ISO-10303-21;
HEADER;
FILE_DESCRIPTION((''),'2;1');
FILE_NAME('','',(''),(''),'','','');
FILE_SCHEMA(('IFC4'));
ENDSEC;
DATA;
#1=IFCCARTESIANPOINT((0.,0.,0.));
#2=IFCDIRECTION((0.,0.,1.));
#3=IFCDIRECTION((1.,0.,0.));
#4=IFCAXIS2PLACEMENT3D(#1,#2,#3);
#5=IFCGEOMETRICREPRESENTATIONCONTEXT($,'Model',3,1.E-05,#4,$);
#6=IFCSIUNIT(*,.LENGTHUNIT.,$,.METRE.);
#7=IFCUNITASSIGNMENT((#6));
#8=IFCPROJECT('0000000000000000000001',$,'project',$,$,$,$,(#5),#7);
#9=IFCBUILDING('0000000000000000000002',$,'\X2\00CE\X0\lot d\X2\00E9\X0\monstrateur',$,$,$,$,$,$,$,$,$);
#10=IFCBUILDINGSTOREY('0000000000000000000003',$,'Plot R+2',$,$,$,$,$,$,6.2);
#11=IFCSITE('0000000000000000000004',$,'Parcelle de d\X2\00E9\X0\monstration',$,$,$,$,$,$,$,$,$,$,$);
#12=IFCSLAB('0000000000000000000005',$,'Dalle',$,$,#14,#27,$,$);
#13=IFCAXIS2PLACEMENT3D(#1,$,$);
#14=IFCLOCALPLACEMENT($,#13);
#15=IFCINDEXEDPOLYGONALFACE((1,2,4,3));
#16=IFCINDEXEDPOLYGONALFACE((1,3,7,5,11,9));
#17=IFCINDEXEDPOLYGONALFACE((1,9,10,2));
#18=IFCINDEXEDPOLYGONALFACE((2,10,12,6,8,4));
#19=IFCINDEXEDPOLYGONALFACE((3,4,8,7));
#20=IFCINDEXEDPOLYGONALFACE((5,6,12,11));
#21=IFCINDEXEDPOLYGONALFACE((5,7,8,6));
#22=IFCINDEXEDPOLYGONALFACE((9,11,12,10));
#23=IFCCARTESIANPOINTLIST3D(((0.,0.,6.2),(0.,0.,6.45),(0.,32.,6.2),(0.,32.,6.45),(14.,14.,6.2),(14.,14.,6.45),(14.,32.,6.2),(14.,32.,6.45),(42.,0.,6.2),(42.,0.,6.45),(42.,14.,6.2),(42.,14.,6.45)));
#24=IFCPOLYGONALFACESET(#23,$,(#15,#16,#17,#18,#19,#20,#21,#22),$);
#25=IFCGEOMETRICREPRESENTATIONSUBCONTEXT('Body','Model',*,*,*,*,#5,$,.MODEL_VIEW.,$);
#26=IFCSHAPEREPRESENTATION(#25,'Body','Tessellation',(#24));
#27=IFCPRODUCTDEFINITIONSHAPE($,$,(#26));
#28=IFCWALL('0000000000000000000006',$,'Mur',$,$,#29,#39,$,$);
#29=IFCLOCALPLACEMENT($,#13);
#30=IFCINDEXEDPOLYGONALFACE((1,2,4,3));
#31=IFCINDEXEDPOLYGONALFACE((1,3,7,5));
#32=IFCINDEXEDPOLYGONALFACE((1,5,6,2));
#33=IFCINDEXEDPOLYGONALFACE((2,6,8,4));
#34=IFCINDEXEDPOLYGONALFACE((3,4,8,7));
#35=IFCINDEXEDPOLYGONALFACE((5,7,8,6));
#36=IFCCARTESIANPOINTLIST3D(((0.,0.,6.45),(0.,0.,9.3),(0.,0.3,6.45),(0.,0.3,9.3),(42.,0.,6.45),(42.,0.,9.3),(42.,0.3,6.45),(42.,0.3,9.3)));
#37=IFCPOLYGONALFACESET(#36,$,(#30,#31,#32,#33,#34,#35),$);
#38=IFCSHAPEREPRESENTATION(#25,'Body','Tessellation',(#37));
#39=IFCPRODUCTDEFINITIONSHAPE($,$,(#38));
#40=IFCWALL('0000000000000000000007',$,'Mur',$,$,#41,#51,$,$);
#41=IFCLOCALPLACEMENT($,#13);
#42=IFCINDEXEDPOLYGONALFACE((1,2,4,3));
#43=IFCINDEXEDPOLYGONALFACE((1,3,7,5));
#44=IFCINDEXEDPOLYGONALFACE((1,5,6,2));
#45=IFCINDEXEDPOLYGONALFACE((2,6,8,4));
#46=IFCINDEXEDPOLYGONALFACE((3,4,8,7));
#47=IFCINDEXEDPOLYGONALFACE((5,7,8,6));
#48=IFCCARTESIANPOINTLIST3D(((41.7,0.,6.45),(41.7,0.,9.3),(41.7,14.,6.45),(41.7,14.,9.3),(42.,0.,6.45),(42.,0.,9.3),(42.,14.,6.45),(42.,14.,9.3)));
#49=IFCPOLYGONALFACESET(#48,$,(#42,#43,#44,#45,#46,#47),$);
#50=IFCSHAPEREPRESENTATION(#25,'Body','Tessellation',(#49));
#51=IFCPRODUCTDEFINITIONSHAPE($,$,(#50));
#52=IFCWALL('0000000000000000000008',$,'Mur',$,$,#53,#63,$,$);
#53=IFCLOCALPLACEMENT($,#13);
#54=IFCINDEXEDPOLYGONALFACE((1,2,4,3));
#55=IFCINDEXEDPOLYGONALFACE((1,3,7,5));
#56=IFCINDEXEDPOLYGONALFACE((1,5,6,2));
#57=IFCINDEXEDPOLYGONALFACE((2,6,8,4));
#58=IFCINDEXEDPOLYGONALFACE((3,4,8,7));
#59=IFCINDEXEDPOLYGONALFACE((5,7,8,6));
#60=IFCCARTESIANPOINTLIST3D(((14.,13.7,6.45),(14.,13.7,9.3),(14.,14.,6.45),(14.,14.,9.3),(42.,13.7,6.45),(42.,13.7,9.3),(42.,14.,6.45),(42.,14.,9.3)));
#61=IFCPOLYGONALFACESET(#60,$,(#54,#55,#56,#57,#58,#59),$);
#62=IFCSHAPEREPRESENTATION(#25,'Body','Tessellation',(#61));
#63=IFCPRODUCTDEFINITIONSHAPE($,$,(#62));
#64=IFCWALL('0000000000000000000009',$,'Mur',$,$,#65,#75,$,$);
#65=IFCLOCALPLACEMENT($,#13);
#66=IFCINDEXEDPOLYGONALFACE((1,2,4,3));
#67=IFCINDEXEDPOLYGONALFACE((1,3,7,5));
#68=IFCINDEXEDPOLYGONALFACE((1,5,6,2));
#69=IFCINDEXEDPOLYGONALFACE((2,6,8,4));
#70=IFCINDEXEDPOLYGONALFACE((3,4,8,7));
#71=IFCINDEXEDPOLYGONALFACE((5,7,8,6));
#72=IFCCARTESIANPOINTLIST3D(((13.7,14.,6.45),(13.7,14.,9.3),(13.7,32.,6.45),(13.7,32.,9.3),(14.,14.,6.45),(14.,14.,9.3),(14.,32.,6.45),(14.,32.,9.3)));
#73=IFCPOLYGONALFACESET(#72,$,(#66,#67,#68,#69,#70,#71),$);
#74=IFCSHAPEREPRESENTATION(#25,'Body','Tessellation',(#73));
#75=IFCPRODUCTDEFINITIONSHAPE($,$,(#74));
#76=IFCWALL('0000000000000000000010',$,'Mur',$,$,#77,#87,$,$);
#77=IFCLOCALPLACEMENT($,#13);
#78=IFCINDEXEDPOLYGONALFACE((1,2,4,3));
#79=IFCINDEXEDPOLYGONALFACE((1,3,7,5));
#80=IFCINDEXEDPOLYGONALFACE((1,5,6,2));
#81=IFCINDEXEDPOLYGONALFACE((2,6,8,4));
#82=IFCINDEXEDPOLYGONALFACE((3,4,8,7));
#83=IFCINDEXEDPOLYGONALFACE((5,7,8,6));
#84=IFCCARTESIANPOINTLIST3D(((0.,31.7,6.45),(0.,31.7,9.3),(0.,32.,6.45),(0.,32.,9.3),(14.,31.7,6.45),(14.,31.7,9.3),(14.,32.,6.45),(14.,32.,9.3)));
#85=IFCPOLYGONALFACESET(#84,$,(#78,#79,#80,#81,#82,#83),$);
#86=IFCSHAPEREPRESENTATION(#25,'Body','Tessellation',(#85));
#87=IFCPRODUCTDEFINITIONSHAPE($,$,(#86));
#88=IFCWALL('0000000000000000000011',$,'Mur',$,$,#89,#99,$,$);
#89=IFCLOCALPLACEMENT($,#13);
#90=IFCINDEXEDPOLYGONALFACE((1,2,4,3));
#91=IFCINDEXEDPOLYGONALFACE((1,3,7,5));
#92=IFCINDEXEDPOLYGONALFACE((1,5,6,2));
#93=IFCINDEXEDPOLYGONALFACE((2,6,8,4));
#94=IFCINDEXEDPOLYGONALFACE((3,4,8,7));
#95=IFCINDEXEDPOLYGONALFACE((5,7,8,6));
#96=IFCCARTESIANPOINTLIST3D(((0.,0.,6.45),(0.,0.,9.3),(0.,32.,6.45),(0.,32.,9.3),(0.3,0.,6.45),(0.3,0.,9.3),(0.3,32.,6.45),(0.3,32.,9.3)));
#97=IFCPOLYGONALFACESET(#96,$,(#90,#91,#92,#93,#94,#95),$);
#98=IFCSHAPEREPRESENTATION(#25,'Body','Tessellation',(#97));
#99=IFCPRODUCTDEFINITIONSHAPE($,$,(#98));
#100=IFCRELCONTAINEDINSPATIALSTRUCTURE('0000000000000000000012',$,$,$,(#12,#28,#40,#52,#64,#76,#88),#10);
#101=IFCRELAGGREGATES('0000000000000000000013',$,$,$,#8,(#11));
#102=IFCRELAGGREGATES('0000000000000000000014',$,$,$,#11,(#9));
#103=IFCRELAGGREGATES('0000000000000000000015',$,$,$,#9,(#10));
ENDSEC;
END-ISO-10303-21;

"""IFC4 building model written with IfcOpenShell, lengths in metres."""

from ifc_helpers import new_model, si_unit, frame, origin_with_axes, place, context, subcontext, project, spatial, indexed_curve, outline, extrude, element, save


model = new_model("IFC4")

# Units and contexts
model_context = context("Model", 3, precision=1e-05, world=origin_with_axes())
body_context = subcontext(model_context, "Body", "Model", "MODEL_VIEW")
ifc_project = project(units=[si_unit("LENGTHUNIT", "METRE")], contexts=[model_context])

# Site, building, storey
site = spatial("IfcSite", under=ifc_project, Name="Parcelle de démonstration")
building = spatial("IfcBuilding", under=site, Name="Îlot démonstrateur")
storey = spatial("IfcBuildingStorey", under=building, Name="Plot R+2", Elevation=6.2)

# Slab
slab_placement = place(None, frame((0.0, 0.0, 6.2), z_axis=(0.0, 0.0, 1.0), x_axis=(1.0, 0.0, 0.0)))
element("IfcSlab", 1, at=slab_placement, inside=storey, Name="Dalle", context=body_context, shape_type="SweptSolid", body=[
    extrude(outline(indexed_curve([(0.0, 0.0), (42.0, 0.0), (42.0, 14.0), (14.0, 14.0), (14.0, 32.0), (0.0, 32.0)])), None, (0.0, 0.0, 1.0), 0.25),
])

# Walls
wall_1_placement = place(None, frame((0.0, 0.0, 6.45), z_axis=(0.0, 0.0, 1.0), x_axis=(1.0, 0.0, 0.0)))
element("IfcWall", 2, at=wall_1_placement, inside=storey, Name="Mur", context=body_context, shape_type="SweptSolid", body=[
    extrude(outline(indexed_curve([(0.0, 0.0), (0.0, 0.3), (42.0, 0.3), (42.0, 0.0), (0.0, 0.0)], self_intersect=False)), origin_with_axes(), (0.0, 0.0, 1.0), 2.85),
])
wall_2_placement = place(None, frame((42.0, 0.0, 6.45), z_axis=(0.0, 0.0, 1.0), x_axis=(0.0, 1.0, 0.0)))
element("IfcWall", 3, at=wall_2_placement, inside=storey, Name="Mur", context=body_context, shape_type="SweptSolid", body=[
    extrude(outline(indexed_curve([(0.0, 0.0), (0.0, 0.3), (14.0, 0.3), (14.0, 0.0), (0.0, 0.0)], self_intersect=False)), origin_with_axes(), (0.0, 0.0, 1.0), 2.85),
])
wall_3_placement = place(None, frame((42.0, 14.0, 6.45), z_axis=(0.0, 0.0, 1.0), x_axis=(-1.0, 0.0, 0.0)))
element("IfcWall", 4, at=wall_3_placement, inside=storey, Name="Mur", context=body_context, shape_type="SweptSolid", body=[
    extrude(outline(indexed_curve([(0.0, 0.0), (0.0, 0.3), (28.0, 0.3), (28.0, 0.0), (0.0, 0.0)], self_intersect=False)), origin_with_axes(), (0.0, 0.0, 1.0), 2.85),
])
wall_4_placement = place(None, frame((14.0, 14.0, 6.45), z_axis=(0.0, 0.0, 1.0), x_axis=(0.0, 1.0, 0.0)))
element("IfcWall", 5, at=wall_4_placement, inside=storey, Name="Mur", context=body_context, shape_type="SweptSolid", body=[
    extrude(outline(indexed_curve([(0.0, 0.0), (0.0, 0.3), (18.0, 0.3), (18.0, 0.0), (0.0, 0.0)], self_intersect=False)), origin_with_axes(), (0.0, 0.0, 1.0), 2.85),
])
wall_5_placement = place(None, frame((14.0, 32.0, 6.45), z_axis=(0.0, 0.0, 1.0), x_axis=(-1.0, 0.0, 0.0)))
element("IfcWall", 6, at=wall_5_placement, inside=storey, Name="Mur", context=body_context, shape_type="SweptSolid", body=[
    extrude(outline(indexed_curve([(0.0, 0.0), (0.0, 0.3), (14.0, 0.3), (14.0, 0.0), (0.0, 0.0)], self_intersect=False)), origin_with_axes(), (0.0, 0.0, 1.0), 2.85),
])
wall_6_placement = place(None, frame((0.0, 32.0, 6.45), z_axis=(0.0, 0.0, 1.0), x_axis=(0.0, -1.0, 0.0)))
element("IfcWall", 7, at=wall_6_placement, inside=storey, Name="Mur", context=body_context, shape_type="SweptSolid", body=[
    extrude(outline(indexed_curve([(0.0, 0.0), (0.0, 0.3), (32.0, 0.3), (32.0, 0.0), (0.0, 0.0)], self_intersect=False)), origin_with_axes(), (0.0, 0.0, 1.0), 2.85),
])

save(model, "model.ifc")
